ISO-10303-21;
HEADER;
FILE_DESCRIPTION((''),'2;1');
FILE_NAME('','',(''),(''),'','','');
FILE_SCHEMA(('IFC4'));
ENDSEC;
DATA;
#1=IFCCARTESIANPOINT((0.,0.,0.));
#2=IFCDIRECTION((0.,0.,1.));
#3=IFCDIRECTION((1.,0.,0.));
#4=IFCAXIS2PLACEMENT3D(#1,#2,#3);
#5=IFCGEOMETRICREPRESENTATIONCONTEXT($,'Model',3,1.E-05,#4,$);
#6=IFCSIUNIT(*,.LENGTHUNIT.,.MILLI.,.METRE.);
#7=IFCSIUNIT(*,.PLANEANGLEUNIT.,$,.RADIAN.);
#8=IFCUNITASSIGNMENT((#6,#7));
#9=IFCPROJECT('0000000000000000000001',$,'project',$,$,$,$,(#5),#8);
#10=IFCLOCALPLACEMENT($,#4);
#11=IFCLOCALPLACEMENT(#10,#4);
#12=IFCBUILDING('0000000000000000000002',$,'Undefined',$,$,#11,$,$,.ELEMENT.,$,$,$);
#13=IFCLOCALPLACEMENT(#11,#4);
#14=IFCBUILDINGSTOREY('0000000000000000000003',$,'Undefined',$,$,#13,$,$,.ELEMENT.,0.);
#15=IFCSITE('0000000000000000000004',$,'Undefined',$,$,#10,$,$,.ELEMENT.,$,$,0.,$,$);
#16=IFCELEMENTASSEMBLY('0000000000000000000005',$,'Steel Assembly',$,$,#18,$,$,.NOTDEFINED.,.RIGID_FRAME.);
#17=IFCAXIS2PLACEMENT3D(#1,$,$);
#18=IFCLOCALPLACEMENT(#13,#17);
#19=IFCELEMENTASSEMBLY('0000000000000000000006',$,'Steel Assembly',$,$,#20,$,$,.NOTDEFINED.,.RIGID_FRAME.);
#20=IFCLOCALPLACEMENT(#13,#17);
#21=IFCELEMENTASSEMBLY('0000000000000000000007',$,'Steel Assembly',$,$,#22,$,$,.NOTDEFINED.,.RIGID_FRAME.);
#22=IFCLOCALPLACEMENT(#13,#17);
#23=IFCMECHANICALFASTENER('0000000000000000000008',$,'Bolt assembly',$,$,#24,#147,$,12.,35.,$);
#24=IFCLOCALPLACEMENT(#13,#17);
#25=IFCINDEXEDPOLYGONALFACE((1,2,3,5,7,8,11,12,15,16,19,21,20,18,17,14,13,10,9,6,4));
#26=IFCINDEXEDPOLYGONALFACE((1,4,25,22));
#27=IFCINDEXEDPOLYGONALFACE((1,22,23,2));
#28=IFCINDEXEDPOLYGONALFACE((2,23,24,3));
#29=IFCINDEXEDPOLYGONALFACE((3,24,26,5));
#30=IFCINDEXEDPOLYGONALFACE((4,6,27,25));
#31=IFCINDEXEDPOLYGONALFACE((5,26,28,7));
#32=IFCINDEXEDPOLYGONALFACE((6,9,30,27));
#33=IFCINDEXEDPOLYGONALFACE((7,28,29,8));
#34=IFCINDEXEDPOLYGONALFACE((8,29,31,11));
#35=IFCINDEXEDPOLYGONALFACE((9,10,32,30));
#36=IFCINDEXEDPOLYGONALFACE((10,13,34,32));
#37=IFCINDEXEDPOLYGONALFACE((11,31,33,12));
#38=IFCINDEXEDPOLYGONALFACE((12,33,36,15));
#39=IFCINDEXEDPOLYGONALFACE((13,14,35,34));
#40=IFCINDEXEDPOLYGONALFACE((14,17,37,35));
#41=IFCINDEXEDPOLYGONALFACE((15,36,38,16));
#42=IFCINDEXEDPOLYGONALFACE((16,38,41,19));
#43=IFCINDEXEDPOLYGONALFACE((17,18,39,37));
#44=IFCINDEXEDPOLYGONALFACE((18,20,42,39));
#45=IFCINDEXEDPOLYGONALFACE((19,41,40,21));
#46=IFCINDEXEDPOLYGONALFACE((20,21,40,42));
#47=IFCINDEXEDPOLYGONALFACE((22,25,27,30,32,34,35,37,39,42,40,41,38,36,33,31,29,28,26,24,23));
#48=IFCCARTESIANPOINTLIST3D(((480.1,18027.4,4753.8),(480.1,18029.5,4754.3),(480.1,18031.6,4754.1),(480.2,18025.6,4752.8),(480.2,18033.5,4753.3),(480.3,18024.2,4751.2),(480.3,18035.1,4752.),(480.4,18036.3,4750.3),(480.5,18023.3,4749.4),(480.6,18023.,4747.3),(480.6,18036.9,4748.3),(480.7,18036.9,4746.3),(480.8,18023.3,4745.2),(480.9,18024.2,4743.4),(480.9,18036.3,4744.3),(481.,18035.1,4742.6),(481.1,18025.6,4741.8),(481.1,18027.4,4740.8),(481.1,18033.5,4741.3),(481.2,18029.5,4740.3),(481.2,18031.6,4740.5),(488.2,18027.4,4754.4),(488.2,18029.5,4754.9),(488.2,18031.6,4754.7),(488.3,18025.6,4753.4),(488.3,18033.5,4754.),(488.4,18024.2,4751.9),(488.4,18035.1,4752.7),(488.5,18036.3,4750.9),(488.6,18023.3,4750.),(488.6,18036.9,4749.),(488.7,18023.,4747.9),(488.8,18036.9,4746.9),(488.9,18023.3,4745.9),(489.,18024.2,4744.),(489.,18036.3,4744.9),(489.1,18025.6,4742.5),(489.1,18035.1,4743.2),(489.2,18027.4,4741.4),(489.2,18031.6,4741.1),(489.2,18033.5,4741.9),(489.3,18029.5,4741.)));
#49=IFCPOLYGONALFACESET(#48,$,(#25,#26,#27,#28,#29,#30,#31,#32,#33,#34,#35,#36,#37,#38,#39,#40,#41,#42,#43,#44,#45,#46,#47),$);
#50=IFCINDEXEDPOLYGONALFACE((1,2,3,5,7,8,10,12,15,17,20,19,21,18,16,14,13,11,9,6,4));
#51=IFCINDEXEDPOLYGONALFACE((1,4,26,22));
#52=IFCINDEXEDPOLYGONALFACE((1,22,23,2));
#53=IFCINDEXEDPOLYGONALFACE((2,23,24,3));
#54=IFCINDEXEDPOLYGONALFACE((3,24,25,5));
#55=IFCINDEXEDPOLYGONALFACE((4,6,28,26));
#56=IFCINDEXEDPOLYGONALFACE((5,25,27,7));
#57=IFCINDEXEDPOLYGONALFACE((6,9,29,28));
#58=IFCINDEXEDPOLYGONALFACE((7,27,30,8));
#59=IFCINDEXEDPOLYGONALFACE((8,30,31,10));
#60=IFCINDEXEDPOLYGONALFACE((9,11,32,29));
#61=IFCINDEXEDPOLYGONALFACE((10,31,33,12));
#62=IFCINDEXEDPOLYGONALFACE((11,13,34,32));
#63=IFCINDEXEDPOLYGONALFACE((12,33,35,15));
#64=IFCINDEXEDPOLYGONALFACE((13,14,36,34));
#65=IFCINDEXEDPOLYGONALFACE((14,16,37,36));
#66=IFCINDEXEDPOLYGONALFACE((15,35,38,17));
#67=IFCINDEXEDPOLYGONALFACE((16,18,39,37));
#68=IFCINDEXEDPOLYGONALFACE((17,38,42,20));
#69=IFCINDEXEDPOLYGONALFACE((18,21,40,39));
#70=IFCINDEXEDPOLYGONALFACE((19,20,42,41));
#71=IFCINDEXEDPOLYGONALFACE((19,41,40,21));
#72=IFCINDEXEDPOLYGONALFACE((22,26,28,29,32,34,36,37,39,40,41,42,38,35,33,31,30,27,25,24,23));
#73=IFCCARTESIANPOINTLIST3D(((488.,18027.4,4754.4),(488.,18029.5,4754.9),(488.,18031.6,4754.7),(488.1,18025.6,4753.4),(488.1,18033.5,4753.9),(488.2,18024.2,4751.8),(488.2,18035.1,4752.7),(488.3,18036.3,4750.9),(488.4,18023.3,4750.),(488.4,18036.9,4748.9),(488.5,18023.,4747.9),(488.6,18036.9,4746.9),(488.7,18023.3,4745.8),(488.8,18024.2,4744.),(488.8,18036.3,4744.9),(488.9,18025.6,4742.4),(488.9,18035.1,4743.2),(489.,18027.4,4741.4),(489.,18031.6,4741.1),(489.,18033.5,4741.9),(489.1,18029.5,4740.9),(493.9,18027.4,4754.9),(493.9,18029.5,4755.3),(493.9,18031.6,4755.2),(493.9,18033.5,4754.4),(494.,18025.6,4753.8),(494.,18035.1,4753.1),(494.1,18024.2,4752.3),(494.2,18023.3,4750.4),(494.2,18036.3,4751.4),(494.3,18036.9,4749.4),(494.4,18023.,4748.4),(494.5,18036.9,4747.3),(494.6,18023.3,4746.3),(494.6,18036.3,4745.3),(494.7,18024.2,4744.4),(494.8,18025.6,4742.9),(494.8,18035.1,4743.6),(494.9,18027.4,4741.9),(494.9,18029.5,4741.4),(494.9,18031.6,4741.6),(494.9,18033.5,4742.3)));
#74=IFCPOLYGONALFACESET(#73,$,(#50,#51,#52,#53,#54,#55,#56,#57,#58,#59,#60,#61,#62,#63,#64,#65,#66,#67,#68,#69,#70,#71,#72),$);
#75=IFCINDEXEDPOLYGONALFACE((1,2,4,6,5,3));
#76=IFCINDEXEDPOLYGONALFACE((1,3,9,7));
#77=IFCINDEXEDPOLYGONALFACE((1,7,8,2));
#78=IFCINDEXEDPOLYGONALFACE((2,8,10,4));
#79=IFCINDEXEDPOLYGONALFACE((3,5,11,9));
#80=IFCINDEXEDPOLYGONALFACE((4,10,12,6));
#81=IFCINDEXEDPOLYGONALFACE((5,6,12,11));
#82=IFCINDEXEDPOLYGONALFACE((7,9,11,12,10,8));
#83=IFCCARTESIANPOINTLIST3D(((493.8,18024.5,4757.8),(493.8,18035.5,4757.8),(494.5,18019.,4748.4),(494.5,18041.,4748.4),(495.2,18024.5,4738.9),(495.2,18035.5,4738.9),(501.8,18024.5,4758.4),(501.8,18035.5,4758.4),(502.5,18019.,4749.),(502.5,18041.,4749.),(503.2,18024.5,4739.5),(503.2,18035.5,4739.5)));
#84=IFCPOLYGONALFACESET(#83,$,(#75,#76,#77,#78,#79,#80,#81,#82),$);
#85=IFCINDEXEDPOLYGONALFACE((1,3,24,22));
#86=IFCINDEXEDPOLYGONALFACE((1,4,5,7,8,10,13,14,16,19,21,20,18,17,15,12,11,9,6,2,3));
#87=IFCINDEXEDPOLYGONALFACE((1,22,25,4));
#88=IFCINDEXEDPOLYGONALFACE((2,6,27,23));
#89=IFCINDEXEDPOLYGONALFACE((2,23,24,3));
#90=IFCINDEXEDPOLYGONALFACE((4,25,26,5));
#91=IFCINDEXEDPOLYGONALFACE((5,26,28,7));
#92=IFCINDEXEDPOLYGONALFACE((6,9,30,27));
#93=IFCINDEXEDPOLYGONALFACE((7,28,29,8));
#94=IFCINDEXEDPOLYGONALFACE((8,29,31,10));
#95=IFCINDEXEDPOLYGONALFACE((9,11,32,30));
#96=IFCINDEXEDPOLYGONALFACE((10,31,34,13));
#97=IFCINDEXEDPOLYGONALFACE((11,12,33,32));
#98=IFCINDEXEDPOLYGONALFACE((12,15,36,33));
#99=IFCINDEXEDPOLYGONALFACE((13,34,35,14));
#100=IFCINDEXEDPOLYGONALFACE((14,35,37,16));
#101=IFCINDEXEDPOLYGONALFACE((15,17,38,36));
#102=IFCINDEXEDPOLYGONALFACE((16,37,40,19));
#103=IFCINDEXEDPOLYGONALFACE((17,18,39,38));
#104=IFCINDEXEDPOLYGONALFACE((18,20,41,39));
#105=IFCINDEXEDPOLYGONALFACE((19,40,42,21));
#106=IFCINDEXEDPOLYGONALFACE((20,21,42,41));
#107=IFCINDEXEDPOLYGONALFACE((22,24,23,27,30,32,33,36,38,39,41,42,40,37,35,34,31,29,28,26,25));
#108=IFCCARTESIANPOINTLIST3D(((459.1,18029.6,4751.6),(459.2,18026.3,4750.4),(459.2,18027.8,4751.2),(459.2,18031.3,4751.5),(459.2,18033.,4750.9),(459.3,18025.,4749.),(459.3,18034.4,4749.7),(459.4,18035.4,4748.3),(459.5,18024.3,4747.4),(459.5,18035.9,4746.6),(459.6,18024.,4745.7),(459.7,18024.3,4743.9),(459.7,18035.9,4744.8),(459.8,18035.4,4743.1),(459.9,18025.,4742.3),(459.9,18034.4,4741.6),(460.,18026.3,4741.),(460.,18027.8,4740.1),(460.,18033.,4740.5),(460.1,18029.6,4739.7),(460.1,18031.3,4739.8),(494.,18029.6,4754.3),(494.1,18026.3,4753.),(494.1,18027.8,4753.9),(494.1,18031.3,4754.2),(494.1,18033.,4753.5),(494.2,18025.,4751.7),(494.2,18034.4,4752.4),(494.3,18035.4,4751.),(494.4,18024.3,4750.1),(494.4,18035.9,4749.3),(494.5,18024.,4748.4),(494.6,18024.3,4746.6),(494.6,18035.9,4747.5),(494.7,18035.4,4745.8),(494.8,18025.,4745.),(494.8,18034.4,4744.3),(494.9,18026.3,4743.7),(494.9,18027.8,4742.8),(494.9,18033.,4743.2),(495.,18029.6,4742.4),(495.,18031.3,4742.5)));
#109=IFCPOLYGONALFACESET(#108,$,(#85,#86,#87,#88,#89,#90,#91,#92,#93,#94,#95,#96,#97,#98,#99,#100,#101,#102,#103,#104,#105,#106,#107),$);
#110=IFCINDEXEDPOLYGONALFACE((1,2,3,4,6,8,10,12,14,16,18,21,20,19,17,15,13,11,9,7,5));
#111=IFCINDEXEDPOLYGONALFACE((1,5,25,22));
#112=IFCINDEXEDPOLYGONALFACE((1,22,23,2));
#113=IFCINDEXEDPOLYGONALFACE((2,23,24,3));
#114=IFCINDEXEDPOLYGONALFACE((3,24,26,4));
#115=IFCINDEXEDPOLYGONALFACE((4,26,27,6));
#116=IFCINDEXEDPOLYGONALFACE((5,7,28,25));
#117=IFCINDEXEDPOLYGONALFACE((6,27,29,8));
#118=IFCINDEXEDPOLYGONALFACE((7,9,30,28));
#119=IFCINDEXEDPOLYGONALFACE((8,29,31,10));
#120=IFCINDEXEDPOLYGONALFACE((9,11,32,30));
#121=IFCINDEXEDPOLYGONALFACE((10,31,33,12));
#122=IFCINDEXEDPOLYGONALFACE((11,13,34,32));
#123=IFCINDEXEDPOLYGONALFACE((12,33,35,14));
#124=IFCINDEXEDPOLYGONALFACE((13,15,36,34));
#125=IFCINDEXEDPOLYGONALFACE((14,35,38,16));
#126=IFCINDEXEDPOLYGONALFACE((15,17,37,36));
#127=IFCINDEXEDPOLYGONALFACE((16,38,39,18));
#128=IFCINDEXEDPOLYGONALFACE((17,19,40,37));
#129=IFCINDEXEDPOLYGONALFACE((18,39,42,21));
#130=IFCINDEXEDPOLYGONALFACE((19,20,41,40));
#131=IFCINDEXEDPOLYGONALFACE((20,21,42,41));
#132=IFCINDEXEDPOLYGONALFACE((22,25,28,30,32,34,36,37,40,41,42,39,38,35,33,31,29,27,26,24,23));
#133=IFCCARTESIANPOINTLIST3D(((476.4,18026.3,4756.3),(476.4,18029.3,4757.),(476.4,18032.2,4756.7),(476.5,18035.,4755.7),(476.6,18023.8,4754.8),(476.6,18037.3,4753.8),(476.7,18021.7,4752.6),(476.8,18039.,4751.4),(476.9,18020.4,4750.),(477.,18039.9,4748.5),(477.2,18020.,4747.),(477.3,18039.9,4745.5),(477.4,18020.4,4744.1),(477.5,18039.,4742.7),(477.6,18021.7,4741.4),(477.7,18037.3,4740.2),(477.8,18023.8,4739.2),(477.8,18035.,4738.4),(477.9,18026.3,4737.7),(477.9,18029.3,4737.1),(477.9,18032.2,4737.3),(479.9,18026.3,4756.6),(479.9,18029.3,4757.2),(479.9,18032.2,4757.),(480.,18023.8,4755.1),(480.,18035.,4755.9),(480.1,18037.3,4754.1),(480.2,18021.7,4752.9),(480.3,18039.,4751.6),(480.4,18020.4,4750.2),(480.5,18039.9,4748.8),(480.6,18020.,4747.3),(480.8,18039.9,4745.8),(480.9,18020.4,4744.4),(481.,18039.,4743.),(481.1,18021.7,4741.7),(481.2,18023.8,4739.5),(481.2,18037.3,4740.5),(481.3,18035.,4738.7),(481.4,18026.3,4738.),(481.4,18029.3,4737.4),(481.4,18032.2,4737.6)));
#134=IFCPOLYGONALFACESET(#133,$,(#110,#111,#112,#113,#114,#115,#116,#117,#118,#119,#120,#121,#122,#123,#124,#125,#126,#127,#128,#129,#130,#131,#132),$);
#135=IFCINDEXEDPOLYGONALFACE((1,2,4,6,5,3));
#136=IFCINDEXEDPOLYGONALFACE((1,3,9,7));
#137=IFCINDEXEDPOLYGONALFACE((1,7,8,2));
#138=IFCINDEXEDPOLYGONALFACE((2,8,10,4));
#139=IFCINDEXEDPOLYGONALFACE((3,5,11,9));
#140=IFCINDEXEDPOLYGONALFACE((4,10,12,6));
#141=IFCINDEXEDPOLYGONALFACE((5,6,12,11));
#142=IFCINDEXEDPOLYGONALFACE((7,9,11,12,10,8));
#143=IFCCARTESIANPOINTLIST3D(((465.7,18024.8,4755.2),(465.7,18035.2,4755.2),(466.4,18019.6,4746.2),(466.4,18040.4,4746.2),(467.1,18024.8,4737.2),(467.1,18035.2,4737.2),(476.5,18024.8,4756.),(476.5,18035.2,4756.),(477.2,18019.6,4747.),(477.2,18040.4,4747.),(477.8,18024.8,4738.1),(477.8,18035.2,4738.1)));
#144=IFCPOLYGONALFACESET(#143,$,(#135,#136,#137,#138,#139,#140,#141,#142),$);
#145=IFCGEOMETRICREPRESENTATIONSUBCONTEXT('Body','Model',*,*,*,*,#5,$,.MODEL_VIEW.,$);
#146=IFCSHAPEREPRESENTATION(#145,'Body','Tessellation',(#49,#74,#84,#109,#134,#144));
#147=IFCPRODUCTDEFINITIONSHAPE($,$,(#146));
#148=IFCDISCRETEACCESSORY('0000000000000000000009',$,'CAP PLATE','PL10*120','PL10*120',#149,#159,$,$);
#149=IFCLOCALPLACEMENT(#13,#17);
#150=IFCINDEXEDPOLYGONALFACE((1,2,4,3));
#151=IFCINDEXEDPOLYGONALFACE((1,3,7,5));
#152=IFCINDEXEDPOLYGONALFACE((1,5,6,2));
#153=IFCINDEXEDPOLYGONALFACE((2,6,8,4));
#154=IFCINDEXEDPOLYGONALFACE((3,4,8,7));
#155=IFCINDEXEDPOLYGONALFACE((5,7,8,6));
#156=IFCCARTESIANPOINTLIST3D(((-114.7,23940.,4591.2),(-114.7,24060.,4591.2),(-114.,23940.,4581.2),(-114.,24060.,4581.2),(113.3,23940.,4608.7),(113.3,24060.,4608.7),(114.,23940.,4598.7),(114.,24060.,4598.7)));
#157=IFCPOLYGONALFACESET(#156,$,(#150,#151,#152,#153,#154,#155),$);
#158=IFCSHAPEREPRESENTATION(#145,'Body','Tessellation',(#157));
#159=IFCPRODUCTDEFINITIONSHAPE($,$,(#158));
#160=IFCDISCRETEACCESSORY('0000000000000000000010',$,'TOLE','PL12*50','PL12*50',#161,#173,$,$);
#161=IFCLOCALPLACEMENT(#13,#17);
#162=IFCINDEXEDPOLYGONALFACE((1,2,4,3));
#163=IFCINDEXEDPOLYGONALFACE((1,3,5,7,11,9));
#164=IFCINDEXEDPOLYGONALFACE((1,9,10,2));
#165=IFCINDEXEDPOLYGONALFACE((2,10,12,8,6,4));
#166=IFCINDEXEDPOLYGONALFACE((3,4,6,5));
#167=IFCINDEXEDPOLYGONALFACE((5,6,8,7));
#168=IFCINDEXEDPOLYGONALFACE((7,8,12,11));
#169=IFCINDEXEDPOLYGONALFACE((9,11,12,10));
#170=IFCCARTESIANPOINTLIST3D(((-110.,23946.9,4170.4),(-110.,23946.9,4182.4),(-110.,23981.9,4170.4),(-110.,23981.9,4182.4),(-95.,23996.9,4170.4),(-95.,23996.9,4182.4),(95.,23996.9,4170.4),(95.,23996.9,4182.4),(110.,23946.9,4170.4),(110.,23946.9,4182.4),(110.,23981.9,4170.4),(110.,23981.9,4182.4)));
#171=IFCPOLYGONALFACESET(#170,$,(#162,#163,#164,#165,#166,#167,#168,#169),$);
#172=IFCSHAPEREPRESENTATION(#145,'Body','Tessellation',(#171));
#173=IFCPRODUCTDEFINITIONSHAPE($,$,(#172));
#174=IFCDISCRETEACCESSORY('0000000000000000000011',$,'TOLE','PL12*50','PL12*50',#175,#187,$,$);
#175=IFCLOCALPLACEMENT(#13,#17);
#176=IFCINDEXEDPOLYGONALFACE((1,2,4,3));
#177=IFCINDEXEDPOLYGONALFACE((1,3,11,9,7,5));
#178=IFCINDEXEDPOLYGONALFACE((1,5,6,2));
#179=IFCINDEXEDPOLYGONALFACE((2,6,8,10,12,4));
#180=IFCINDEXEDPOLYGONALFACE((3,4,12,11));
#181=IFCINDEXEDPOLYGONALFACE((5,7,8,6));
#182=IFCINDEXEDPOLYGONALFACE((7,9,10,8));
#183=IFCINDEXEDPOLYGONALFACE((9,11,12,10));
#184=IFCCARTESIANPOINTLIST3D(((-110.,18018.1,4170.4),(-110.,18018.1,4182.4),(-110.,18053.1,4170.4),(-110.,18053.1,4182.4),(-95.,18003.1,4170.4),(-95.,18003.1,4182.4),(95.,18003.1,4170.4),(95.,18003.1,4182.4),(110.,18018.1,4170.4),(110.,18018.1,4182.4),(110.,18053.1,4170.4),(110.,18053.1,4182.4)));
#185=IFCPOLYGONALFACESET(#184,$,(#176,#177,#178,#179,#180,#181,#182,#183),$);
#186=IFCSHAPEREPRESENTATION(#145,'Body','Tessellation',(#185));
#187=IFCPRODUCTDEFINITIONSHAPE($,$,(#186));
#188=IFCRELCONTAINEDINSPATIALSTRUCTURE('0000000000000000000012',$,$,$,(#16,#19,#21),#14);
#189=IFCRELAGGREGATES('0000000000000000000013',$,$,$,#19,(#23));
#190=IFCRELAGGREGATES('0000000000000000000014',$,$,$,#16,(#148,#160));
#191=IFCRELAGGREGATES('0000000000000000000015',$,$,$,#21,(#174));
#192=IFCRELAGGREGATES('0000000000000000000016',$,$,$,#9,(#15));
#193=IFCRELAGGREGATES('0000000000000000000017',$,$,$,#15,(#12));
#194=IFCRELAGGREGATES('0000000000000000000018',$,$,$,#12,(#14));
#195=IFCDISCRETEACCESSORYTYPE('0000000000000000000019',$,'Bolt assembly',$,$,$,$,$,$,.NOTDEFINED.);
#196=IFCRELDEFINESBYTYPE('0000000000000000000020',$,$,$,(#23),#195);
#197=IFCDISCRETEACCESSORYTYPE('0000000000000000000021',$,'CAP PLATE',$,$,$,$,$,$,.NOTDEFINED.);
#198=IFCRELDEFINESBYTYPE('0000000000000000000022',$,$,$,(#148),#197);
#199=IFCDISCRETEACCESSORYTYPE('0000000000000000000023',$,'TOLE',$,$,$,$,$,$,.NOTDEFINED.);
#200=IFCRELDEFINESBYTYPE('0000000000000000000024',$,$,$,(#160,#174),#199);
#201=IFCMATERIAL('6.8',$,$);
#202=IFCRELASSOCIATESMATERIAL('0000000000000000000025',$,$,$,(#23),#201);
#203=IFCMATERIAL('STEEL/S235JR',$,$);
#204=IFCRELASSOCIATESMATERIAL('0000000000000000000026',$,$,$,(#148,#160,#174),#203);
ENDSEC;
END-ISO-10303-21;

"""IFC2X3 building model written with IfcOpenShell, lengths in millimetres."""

from ifc_helpers import new_model, si_unit, frame, origin_with_axes, origin_2d_with_axis, place, context, subcontext, project, spatial, polyline, rectangle, circle, outline, extrude, clip, halfspace, source, transform, mapped, material, type_object, element, aggregate, save


model = new_model("IFC2X3")

# Units and contexts
model_context = context("Model", 3, precision=1e-05, world=origin_with_axes())
body_context = subcontext(model_context, "Body", "Model", "MODEL_VIEW")
ifc_project = project(units=[si_unit("LENGTHUNIT", "METRE", prefix="MILLI"), si_unit("PLANEANGLEUNIT", "RADIAN")], contexts=[model_context])

# Site, building, storey
site_placement = place(None, origin_with_axes())
site = spatial("IfcSite", under=ifc_project, at=site_placement, Name="Undefined", CompositionType="ELEMENT", RefElevation=0.0)
building_placement = place(site_placement, origin_with_axes())
building = spatial("IfcBuilding", under=site, at=building_placement, Name="Undefined", CompositionType="ELEMENT")
storey_placement = place(building_placement, origin_with_axes())
storey = spatial("IfcBuildingStorey", under=building, at=storey_placement, Name="Undefined", CompositionType="ELEMENT", Elevation=0.0)

# Element assembly
assembly_1_placement = place(storey_placement, origin_with_axes())
assembly_1 = element("IfcElementAssembly", 1, at=assembly_1_placement, inside=storey, Name="Steel Assembly", AssemblyPlace="NOTDEFINED", PredefinedType="RIGID_FRAME")
ifc_material_1 = material(Name="STEEL/S235JR")

# Element assembly
assembly_2_placement = place(storey_placement, origin_with_axes())
assembly_2 = element("IfcElementAssembly", 2, at=assembly_2_placement, inside=storey, Name="Steel Assembly", AssemblyPlace="NOTDEFINED", PredefinedType="RIGID_FRAME")
ifc_material_2 = material(Name="6.8")
discrete_accessory_type_1 = type_object("IfcDiscreteAccessoryType", Name="Bolt assembly")

# Element assembly
assembly_3_placement = place(storey_placement, origin_with_axes())
assembly_3 = element("IfcElementAssembly", 3, at=assembly_3_placement, inside=storey, Name="Steel Assembly", AssemblyPlace="NOTDEFINED", PredefinedType="RIGID_FRAME")

# Mechanical fastener
shared_shape_1 = source(origin_with_axes(), body_context, "Body", "SweptSolid", [
    extrude(circle(Radius=7.0, at=origin_2d_with_axis()), frame((0.0, 2.9, 0.0), z_axis=(0.0, 1.0, 0.0), x_axis=(1.0, 0.0, 0.0)), (0.0, 0.0, 1.0), 8.1),
    extrude(circle(Radius=7.0, at=origin_2d_with_axis()), frame((0.0, -2.9, 0.0), z_axis=(0.0, 1.0, 0.0), x_axis=(1.0, 0.0, 0.0)), (0.0, 0.0, 1.0), 5.9),
    extrude(outline(polyline([(11.0, 0.0), (5.5, 9.5), (-5.5, 9.5), (-11.0, 0.0), (-5.5, -9.5), (5.5, -9.5), (11.0, 0.0)])), frame((0.0, -11.0, 0.0), z_axis=(0.0, 1.0, 0.0), x_axis=(1.0, 0.0, 0.0)), (0.0, 0.0, 1.0), 8.0),
    extrude(circle(Radius=6.0, at=origin_2d_with_axis()), frame((0.0, -3.0, 0.0), z_axis=(0.0, 1.0, 0.0), x_axis=(1.0, 0.0, 0.0)), (0.0, 0.0, 1.0), 35.0),
    extrude(circle(Radius=10.0, at=origin_2d_with_axis()), frame((0.0, 11.0, 0.0), z_axis=(0.0, 1.0, 0.0), x_axis=(1.0, 0.0, 0.0)), (0.0, 0.0, 1.0), 3.5),
    extrude(outline(polyline([(10.4, 0.0), (5.2, 9.0), (-5.2, 9.0), (-10.4, 0.0), (-5.2, -9.0), (5.2, -9.0), (10.4, 0.0)])), frame((0.0, 14.5, 0.0), z_axis=(0.0, 1.0, 0.0), x_axis=(1.0, 0.0, 0.0)), (0.0, 0.0, 1.0), 10.8),
])
mechanical_fastener_1_placement = place(assembly_2_placement, frame((491.6, 18030.0, 4748.1), z_axis=(0.076696, 0.0, -0.997054), x_axis=(0.0, -1.0, 0.0)))
mechanical_fastener_1 = element("IfcMechanicalFastener", 4, at=mechanical_fastener_1_placement, type_object=discrete_accessory_type_1, material=ifc_material_2, Name="Bolt assembly", NominalDiameter=12.0, NominalLength=35.0, context=body_context, shape_type="MappedRepresentation", body=[
    mapped(shared_shape_1, transform((0.0, 0.0, 0.0))),
])
aggregate(assembly_2, [mechanical_fastener_1])

# Discrete accessories
discrete_accessory_type_2 = type_object("IfcDiscreteAccessoryType", Name="CAP PLATE")
discrete_accessory_1_placement = place(assembly_1_placement, frame((113.6, 24000.0, 4603.7), z_axis=(-0.076696, 0.0, 0.997054), x_axis=(-0.997054, 0.0, -0.076696)))
discrete_accessory_1 = element("IfcDiscreteAccessory", 5, at=discrete_accessory_1_placement, type_object=discrete_accessory_type_2, material=ifc_material_1, Name="CAP PLATE", Description="PL10*120", ObjectType="PL10*120", context=body_context, shape_type="SweptSolid", body=[
    extrude(outline(polyline([(228.7, 60.0), (228.7, -60.0), (0.0, -60.0), (0.0, 60.0), (228.7, 60.0)])), frame((0.0, 0.0, -5.0), z_axis=(0.0, 0.0, 1.0), x_axis=(1.0, 0.0, 0.0)), (0.0, 0.0, 1.0), 10.0),
])
discrete_accessory_type_3 = type_object("IfcDiscreteAccessoryType", Name="TOLE")
discrete_accessory_2_placement = place(assembly_1_placement, frame((-110.0, 23971.9, 4176.4), z_axis=(0.0, -1.0, 0.0), x_axis=(1.0, 0.0, 0.0)))
discrete_accessory_2 = element("IfcDiscreteAccessory", 6, at=discrete_accessory_2_placement, type_object=discrete_accessory_type_3, material=ifc_material_1, Name="TOLE", Description="PL12*50", ObjectType="PL12*50", context=body_context, shape_type="Clipping", body=[
    clip(clip(extrude(rectangle(XDim=12.0, YDim=50.0, at=origin_2d_with_axis()), frame((220.0, 0.0, 0.0), z_axis=(-1.0, 0.0, 0.0), x_axis=(0.0, -1.0, 0.0)), (0.0, 0.0, 1.0), 220.0), halfspace(frame((15.0, 6.0, -25.0), z_axis=(-0.707107, 0.0, -0.707107), x_axis=(-0.707107, 0.0, 0.707107)), False)), halfspace(frame((205.0, -6.0, -25.0), z_axis=(0.707107, 0.0, -0.707107), x_axis=(0.707107, 0.0, 0.707107)), False)),
])
aggregate(assembly_1, [discrete_accessory_1, discrete_accessory_2])
discrete_accessory_3_placement = place(assembly_3_placement, frame((-110.0, 18028.1, 4176.4), z_axis=(0.0, -1.0, 0.0), x_axis=(1.0, 0.0, 0.0)))
discrete_accessory_3 = element("IfcDiscreteAccessory", 7, at=discrete_accessory_3_placement, type_object=discrete_accessory_type_3, material=ifc_material_1, Name="TOLE", Description="PL12*50", ObjectType="PL12*50", context=body_context, shape_type="Clipping", body=[
    clip(clip(extrude(rectangle(XDim=12.0, YDim=50.0, at=origin_2d_with_axis()), frame((220.0, 0.0, 0.0), z_axis=(-1.0, 0.0, 0.0), x_axis=(0.0, -1.0, 0.0)), (0.0, 0.0, 1.0), 220.0), halfspace(frame((-35.0, 6.0, -25.0), z_axis=(-0.707107, 0.0, 0.707107), x_axis=(0.707107, 0.0, 0.707107)), False)), halfspace(frame((255.0, -6.0, -25.0), z_axis=(0.707107, 0.0, 0.707107), x_axis=(-0.707107, 0.0, 0.707107)), False)),
])
aggregate(assembly_3, [discrete_accessory_3])

save(model, "model.ifc")
